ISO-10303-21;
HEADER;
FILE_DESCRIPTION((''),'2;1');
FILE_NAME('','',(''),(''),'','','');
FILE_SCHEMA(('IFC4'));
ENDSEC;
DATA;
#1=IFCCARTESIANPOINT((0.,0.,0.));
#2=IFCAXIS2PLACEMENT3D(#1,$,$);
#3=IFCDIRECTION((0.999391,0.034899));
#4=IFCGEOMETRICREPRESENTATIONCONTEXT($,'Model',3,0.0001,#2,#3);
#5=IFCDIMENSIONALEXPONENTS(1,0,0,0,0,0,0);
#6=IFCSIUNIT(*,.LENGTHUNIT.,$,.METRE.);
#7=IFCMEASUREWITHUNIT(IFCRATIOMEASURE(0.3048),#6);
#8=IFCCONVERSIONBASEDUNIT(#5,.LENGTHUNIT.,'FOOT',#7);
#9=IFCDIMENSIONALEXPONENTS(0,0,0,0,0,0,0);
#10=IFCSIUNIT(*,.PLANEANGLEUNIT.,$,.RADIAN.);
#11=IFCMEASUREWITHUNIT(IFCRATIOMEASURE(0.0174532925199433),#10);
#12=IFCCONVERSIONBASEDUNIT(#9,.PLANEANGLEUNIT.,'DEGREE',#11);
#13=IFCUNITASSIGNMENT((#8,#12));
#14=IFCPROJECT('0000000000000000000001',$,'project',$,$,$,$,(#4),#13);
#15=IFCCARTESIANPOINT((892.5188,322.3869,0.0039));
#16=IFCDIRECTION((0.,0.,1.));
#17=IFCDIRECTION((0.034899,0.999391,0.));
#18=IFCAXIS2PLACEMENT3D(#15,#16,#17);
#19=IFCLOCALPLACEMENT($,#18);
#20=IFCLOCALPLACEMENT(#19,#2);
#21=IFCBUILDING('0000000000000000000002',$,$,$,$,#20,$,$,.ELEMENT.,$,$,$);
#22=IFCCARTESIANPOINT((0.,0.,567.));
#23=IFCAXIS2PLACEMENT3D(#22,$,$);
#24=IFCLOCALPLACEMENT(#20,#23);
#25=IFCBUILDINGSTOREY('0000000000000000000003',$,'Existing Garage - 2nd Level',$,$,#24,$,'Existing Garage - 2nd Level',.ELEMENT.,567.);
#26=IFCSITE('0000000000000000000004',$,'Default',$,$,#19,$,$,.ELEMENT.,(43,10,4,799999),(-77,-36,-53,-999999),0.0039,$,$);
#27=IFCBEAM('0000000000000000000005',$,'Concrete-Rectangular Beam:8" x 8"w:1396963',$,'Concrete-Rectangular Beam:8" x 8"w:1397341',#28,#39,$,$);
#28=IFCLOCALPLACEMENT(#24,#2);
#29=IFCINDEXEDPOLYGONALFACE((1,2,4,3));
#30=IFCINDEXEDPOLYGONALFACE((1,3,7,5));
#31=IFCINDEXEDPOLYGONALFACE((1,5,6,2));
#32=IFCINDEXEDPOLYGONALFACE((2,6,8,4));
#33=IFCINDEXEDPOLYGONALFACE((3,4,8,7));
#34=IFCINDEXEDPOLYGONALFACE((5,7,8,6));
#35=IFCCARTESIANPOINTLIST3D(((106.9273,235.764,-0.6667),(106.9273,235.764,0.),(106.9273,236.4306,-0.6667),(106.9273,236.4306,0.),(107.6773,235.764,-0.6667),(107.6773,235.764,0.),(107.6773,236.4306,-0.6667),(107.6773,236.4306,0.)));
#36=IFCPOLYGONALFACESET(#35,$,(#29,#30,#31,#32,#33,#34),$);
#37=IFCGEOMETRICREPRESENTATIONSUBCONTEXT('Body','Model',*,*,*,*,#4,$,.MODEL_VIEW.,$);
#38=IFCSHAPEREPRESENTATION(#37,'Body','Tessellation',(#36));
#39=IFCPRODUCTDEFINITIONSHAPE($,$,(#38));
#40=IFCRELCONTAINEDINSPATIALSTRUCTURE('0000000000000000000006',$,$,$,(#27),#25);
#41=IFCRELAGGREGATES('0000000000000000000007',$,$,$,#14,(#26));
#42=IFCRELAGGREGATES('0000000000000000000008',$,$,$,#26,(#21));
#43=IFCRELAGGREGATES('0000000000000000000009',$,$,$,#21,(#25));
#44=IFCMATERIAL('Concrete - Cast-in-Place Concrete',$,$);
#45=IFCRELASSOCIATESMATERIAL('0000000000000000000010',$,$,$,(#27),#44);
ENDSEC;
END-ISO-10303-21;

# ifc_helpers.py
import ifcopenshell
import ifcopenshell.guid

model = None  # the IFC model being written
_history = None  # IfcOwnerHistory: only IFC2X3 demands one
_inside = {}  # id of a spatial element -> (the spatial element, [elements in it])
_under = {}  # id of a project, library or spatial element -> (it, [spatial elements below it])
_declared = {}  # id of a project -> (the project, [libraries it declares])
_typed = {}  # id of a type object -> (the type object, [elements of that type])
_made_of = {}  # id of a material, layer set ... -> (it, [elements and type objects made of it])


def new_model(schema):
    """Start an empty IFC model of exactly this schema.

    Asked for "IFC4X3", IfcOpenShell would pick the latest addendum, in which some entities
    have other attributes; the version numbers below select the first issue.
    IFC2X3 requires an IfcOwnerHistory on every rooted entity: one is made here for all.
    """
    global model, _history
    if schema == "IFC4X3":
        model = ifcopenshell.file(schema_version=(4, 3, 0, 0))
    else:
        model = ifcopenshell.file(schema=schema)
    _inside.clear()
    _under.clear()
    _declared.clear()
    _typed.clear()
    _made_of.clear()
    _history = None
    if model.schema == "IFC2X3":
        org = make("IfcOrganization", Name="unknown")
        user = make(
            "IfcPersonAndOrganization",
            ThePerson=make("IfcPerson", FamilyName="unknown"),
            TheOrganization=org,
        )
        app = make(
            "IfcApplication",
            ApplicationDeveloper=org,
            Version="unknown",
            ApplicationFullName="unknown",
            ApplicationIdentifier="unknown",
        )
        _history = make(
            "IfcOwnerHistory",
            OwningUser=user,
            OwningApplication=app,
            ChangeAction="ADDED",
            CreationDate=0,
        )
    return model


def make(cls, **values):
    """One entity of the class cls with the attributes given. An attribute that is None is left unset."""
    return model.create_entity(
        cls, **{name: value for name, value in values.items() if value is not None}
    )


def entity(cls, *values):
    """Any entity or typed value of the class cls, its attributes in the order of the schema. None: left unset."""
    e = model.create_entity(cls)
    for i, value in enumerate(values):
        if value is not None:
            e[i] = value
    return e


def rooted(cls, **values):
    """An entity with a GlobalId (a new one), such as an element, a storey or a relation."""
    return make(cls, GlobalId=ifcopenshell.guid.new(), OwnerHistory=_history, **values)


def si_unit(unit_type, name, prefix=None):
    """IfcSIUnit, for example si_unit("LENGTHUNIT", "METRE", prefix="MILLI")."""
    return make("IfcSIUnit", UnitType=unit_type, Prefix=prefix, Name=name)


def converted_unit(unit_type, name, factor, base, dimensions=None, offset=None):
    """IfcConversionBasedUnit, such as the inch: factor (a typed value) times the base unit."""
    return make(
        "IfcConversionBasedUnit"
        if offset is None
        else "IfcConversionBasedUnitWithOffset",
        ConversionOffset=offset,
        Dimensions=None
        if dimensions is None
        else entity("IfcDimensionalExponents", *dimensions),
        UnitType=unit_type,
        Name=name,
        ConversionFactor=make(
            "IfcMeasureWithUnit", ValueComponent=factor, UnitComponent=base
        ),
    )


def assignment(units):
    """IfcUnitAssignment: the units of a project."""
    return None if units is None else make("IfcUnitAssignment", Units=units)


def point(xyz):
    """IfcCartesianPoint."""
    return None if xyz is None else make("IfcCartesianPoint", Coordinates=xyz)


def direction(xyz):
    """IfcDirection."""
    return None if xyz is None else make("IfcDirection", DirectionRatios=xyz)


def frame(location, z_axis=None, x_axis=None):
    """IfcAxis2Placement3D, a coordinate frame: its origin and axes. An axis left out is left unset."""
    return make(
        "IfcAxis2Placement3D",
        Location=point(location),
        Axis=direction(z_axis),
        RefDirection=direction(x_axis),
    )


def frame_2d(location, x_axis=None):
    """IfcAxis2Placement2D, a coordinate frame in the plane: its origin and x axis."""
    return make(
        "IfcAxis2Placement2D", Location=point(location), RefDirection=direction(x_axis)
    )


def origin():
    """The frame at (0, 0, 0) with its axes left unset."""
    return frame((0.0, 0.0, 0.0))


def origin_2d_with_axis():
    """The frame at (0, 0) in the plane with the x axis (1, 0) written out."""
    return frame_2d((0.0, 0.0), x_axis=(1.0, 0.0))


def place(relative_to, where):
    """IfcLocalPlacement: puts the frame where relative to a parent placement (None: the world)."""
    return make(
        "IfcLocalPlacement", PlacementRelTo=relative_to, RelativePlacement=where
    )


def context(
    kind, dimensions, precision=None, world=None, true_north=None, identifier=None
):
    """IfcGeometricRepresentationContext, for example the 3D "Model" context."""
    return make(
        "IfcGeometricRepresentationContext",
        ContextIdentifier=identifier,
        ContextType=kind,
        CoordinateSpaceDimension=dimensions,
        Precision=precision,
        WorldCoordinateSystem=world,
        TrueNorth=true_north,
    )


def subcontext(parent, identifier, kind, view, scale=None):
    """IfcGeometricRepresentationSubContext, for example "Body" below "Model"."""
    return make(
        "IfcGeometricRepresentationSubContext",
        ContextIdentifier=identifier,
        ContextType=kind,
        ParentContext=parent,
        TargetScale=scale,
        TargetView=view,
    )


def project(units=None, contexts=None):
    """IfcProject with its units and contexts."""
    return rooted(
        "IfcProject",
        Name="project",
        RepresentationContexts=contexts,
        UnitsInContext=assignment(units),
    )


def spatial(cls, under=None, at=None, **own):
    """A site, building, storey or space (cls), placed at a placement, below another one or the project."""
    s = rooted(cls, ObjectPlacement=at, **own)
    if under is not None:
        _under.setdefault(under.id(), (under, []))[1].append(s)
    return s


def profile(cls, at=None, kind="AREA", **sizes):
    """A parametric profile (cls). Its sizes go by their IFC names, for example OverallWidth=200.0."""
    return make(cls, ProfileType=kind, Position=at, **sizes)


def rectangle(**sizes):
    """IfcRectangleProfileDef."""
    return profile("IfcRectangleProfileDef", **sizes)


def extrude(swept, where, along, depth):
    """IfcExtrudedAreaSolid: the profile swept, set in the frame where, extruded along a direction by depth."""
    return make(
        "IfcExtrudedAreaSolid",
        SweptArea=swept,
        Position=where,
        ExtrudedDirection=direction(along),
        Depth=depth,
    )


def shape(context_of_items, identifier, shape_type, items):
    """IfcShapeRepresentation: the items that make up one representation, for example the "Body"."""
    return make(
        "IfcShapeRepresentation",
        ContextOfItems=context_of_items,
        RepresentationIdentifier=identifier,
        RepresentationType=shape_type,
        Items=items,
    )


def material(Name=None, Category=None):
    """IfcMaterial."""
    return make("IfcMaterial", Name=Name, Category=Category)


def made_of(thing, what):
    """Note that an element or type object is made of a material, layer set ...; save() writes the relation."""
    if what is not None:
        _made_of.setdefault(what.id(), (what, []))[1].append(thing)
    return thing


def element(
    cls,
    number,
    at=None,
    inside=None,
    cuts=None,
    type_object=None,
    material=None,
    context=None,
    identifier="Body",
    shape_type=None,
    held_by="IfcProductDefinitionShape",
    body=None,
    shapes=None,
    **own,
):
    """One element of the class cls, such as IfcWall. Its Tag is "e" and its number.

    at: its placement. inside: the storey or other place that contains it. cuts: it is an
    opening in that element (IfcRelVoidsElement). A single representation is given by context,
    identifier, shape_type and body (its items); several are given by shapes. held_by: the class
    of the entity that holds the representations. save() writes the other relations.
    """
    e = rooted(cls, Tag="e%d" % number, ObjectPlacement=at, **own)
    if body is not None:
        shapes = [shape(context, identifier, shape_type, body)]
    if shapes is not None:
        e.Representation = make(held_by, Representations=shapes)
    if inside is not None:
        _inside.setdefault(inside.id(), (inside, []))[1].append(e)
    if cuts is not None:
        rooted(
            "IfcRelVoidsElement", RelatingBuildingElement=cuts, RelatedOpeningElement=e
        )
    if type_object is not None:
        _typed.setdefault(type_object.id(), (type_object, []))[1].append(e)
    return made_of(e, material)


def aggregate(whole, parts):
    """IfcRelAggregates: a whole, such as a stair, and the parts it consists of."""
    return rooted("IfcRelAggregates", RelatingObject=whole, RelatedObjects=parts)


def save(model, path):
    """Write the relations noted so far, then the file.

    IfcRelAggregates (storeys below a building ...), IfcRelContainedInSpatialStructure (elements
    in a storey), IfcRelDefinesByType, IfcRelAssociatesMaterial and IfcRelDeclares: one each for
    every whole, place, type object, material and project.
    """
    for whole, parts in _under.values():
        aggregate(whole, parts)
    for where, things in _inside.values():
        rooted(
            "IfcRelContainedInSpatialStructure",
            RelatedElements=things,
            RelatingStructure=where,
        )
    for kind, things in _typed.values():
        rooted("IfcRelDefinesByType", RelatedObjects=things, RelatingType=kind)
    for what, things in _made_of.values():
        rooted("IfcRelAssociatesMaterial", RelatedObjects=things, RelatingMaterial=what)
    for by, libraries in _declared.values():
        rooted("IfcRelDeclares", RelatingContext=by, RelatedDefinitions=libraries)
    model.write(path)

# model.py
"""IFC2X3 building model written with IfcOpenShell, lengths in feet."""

from ifc_helpers import new_model, entity, si_unit, converted_unit, direction, frame, origin, origin_2d_with_axis, place, context, subcontext, project, spatial, rectangle, extrude, material, element, save


model = new_model("IFC2X3")

# Units and contexts
model_context = context("Model", 3, precision=0.0001, world=origin(), true_north=direction((0.999391, 0.034899)))
body_context = subcontext(model_context, "Body", "Model", "MODEL_VIEW")
ifc_project = project(units=[converted_unit("LENGTHUNIT", "FOOT", entity("IfcRatioMeasure", 0.3048), si_unit("LENGTHUNIT", "METRE"), dimensions=[1, 0, 0, 0, 0, 0, 0]), converted_unit("PLANEANGLEUNIT", "DEGREE", entity("IfcRatioMeasure", 0.0174532925199433), si_unit("PLANEANGLEUNIT", "RADIAN"), dimensions=[0, 0, 0, 0, 0, 0, 0])], contexts=[model_context])

# Site, building, storey
site_placement = place(None, frame((892.5188, 322.3869, 0.0039), z_axis=(0.0, 0.0, 1.0), x_axis=(0.034899, 0.999391, 0.0)))
site = spatial("IfcSite", under=ifc_project, at=site_placement, Name="Default", CompositionType="ELEMENT", RefLatitude=(43, 10, 4, 799999), RefLongitude=(-77, -36, -53, -999999), RefElevation=0.0039)
building_placement = place(site_placement, origin())
building = spatial("IfcBuilding", under=site, at=building_placement, CompositionType="ELEMENT")
storey_placement = place(building_placement, frame((0.0, 0.0, 567.0)))
storey = spatial("IfcBuildingStorey", under=building, at=storey_placement, Name="Existing Garage - 2nd Level", LongName="Existing Garage - 2nd Level", CompositionType="ELEMENT", Elevation=567.0)

# Beam
ifc_material_1 = material(Name="Concrete - Cast-in-Place Concrete")
beam_placement = place(storey_placement, frame((105.9273, 236.0973, 0.0)))
element("IfcBeam", 1, at=beam_placement, inside=storey, material=ifc_material_1, Name="Concrete-Rectangular Beam:8\" x 8\"w:1396963", ObjectType="Concrete-Rectangular Beam:8\" x 8\"w:1397341", context=body_context, shape_type="SweptSolid", body=[
    extrude(rectangle(XDim=0.6667, YDim=0.6667, at=origin_2d_with_axis()), frame((1.0, 0.0, -0.3333), z_axis=(1.0, 0.0, 0.0), x_axis=(0.0, 0.0, -1.0)), (0.0, 0.0, 1.0), 0.75),
])

save(model, "model.ifc")
